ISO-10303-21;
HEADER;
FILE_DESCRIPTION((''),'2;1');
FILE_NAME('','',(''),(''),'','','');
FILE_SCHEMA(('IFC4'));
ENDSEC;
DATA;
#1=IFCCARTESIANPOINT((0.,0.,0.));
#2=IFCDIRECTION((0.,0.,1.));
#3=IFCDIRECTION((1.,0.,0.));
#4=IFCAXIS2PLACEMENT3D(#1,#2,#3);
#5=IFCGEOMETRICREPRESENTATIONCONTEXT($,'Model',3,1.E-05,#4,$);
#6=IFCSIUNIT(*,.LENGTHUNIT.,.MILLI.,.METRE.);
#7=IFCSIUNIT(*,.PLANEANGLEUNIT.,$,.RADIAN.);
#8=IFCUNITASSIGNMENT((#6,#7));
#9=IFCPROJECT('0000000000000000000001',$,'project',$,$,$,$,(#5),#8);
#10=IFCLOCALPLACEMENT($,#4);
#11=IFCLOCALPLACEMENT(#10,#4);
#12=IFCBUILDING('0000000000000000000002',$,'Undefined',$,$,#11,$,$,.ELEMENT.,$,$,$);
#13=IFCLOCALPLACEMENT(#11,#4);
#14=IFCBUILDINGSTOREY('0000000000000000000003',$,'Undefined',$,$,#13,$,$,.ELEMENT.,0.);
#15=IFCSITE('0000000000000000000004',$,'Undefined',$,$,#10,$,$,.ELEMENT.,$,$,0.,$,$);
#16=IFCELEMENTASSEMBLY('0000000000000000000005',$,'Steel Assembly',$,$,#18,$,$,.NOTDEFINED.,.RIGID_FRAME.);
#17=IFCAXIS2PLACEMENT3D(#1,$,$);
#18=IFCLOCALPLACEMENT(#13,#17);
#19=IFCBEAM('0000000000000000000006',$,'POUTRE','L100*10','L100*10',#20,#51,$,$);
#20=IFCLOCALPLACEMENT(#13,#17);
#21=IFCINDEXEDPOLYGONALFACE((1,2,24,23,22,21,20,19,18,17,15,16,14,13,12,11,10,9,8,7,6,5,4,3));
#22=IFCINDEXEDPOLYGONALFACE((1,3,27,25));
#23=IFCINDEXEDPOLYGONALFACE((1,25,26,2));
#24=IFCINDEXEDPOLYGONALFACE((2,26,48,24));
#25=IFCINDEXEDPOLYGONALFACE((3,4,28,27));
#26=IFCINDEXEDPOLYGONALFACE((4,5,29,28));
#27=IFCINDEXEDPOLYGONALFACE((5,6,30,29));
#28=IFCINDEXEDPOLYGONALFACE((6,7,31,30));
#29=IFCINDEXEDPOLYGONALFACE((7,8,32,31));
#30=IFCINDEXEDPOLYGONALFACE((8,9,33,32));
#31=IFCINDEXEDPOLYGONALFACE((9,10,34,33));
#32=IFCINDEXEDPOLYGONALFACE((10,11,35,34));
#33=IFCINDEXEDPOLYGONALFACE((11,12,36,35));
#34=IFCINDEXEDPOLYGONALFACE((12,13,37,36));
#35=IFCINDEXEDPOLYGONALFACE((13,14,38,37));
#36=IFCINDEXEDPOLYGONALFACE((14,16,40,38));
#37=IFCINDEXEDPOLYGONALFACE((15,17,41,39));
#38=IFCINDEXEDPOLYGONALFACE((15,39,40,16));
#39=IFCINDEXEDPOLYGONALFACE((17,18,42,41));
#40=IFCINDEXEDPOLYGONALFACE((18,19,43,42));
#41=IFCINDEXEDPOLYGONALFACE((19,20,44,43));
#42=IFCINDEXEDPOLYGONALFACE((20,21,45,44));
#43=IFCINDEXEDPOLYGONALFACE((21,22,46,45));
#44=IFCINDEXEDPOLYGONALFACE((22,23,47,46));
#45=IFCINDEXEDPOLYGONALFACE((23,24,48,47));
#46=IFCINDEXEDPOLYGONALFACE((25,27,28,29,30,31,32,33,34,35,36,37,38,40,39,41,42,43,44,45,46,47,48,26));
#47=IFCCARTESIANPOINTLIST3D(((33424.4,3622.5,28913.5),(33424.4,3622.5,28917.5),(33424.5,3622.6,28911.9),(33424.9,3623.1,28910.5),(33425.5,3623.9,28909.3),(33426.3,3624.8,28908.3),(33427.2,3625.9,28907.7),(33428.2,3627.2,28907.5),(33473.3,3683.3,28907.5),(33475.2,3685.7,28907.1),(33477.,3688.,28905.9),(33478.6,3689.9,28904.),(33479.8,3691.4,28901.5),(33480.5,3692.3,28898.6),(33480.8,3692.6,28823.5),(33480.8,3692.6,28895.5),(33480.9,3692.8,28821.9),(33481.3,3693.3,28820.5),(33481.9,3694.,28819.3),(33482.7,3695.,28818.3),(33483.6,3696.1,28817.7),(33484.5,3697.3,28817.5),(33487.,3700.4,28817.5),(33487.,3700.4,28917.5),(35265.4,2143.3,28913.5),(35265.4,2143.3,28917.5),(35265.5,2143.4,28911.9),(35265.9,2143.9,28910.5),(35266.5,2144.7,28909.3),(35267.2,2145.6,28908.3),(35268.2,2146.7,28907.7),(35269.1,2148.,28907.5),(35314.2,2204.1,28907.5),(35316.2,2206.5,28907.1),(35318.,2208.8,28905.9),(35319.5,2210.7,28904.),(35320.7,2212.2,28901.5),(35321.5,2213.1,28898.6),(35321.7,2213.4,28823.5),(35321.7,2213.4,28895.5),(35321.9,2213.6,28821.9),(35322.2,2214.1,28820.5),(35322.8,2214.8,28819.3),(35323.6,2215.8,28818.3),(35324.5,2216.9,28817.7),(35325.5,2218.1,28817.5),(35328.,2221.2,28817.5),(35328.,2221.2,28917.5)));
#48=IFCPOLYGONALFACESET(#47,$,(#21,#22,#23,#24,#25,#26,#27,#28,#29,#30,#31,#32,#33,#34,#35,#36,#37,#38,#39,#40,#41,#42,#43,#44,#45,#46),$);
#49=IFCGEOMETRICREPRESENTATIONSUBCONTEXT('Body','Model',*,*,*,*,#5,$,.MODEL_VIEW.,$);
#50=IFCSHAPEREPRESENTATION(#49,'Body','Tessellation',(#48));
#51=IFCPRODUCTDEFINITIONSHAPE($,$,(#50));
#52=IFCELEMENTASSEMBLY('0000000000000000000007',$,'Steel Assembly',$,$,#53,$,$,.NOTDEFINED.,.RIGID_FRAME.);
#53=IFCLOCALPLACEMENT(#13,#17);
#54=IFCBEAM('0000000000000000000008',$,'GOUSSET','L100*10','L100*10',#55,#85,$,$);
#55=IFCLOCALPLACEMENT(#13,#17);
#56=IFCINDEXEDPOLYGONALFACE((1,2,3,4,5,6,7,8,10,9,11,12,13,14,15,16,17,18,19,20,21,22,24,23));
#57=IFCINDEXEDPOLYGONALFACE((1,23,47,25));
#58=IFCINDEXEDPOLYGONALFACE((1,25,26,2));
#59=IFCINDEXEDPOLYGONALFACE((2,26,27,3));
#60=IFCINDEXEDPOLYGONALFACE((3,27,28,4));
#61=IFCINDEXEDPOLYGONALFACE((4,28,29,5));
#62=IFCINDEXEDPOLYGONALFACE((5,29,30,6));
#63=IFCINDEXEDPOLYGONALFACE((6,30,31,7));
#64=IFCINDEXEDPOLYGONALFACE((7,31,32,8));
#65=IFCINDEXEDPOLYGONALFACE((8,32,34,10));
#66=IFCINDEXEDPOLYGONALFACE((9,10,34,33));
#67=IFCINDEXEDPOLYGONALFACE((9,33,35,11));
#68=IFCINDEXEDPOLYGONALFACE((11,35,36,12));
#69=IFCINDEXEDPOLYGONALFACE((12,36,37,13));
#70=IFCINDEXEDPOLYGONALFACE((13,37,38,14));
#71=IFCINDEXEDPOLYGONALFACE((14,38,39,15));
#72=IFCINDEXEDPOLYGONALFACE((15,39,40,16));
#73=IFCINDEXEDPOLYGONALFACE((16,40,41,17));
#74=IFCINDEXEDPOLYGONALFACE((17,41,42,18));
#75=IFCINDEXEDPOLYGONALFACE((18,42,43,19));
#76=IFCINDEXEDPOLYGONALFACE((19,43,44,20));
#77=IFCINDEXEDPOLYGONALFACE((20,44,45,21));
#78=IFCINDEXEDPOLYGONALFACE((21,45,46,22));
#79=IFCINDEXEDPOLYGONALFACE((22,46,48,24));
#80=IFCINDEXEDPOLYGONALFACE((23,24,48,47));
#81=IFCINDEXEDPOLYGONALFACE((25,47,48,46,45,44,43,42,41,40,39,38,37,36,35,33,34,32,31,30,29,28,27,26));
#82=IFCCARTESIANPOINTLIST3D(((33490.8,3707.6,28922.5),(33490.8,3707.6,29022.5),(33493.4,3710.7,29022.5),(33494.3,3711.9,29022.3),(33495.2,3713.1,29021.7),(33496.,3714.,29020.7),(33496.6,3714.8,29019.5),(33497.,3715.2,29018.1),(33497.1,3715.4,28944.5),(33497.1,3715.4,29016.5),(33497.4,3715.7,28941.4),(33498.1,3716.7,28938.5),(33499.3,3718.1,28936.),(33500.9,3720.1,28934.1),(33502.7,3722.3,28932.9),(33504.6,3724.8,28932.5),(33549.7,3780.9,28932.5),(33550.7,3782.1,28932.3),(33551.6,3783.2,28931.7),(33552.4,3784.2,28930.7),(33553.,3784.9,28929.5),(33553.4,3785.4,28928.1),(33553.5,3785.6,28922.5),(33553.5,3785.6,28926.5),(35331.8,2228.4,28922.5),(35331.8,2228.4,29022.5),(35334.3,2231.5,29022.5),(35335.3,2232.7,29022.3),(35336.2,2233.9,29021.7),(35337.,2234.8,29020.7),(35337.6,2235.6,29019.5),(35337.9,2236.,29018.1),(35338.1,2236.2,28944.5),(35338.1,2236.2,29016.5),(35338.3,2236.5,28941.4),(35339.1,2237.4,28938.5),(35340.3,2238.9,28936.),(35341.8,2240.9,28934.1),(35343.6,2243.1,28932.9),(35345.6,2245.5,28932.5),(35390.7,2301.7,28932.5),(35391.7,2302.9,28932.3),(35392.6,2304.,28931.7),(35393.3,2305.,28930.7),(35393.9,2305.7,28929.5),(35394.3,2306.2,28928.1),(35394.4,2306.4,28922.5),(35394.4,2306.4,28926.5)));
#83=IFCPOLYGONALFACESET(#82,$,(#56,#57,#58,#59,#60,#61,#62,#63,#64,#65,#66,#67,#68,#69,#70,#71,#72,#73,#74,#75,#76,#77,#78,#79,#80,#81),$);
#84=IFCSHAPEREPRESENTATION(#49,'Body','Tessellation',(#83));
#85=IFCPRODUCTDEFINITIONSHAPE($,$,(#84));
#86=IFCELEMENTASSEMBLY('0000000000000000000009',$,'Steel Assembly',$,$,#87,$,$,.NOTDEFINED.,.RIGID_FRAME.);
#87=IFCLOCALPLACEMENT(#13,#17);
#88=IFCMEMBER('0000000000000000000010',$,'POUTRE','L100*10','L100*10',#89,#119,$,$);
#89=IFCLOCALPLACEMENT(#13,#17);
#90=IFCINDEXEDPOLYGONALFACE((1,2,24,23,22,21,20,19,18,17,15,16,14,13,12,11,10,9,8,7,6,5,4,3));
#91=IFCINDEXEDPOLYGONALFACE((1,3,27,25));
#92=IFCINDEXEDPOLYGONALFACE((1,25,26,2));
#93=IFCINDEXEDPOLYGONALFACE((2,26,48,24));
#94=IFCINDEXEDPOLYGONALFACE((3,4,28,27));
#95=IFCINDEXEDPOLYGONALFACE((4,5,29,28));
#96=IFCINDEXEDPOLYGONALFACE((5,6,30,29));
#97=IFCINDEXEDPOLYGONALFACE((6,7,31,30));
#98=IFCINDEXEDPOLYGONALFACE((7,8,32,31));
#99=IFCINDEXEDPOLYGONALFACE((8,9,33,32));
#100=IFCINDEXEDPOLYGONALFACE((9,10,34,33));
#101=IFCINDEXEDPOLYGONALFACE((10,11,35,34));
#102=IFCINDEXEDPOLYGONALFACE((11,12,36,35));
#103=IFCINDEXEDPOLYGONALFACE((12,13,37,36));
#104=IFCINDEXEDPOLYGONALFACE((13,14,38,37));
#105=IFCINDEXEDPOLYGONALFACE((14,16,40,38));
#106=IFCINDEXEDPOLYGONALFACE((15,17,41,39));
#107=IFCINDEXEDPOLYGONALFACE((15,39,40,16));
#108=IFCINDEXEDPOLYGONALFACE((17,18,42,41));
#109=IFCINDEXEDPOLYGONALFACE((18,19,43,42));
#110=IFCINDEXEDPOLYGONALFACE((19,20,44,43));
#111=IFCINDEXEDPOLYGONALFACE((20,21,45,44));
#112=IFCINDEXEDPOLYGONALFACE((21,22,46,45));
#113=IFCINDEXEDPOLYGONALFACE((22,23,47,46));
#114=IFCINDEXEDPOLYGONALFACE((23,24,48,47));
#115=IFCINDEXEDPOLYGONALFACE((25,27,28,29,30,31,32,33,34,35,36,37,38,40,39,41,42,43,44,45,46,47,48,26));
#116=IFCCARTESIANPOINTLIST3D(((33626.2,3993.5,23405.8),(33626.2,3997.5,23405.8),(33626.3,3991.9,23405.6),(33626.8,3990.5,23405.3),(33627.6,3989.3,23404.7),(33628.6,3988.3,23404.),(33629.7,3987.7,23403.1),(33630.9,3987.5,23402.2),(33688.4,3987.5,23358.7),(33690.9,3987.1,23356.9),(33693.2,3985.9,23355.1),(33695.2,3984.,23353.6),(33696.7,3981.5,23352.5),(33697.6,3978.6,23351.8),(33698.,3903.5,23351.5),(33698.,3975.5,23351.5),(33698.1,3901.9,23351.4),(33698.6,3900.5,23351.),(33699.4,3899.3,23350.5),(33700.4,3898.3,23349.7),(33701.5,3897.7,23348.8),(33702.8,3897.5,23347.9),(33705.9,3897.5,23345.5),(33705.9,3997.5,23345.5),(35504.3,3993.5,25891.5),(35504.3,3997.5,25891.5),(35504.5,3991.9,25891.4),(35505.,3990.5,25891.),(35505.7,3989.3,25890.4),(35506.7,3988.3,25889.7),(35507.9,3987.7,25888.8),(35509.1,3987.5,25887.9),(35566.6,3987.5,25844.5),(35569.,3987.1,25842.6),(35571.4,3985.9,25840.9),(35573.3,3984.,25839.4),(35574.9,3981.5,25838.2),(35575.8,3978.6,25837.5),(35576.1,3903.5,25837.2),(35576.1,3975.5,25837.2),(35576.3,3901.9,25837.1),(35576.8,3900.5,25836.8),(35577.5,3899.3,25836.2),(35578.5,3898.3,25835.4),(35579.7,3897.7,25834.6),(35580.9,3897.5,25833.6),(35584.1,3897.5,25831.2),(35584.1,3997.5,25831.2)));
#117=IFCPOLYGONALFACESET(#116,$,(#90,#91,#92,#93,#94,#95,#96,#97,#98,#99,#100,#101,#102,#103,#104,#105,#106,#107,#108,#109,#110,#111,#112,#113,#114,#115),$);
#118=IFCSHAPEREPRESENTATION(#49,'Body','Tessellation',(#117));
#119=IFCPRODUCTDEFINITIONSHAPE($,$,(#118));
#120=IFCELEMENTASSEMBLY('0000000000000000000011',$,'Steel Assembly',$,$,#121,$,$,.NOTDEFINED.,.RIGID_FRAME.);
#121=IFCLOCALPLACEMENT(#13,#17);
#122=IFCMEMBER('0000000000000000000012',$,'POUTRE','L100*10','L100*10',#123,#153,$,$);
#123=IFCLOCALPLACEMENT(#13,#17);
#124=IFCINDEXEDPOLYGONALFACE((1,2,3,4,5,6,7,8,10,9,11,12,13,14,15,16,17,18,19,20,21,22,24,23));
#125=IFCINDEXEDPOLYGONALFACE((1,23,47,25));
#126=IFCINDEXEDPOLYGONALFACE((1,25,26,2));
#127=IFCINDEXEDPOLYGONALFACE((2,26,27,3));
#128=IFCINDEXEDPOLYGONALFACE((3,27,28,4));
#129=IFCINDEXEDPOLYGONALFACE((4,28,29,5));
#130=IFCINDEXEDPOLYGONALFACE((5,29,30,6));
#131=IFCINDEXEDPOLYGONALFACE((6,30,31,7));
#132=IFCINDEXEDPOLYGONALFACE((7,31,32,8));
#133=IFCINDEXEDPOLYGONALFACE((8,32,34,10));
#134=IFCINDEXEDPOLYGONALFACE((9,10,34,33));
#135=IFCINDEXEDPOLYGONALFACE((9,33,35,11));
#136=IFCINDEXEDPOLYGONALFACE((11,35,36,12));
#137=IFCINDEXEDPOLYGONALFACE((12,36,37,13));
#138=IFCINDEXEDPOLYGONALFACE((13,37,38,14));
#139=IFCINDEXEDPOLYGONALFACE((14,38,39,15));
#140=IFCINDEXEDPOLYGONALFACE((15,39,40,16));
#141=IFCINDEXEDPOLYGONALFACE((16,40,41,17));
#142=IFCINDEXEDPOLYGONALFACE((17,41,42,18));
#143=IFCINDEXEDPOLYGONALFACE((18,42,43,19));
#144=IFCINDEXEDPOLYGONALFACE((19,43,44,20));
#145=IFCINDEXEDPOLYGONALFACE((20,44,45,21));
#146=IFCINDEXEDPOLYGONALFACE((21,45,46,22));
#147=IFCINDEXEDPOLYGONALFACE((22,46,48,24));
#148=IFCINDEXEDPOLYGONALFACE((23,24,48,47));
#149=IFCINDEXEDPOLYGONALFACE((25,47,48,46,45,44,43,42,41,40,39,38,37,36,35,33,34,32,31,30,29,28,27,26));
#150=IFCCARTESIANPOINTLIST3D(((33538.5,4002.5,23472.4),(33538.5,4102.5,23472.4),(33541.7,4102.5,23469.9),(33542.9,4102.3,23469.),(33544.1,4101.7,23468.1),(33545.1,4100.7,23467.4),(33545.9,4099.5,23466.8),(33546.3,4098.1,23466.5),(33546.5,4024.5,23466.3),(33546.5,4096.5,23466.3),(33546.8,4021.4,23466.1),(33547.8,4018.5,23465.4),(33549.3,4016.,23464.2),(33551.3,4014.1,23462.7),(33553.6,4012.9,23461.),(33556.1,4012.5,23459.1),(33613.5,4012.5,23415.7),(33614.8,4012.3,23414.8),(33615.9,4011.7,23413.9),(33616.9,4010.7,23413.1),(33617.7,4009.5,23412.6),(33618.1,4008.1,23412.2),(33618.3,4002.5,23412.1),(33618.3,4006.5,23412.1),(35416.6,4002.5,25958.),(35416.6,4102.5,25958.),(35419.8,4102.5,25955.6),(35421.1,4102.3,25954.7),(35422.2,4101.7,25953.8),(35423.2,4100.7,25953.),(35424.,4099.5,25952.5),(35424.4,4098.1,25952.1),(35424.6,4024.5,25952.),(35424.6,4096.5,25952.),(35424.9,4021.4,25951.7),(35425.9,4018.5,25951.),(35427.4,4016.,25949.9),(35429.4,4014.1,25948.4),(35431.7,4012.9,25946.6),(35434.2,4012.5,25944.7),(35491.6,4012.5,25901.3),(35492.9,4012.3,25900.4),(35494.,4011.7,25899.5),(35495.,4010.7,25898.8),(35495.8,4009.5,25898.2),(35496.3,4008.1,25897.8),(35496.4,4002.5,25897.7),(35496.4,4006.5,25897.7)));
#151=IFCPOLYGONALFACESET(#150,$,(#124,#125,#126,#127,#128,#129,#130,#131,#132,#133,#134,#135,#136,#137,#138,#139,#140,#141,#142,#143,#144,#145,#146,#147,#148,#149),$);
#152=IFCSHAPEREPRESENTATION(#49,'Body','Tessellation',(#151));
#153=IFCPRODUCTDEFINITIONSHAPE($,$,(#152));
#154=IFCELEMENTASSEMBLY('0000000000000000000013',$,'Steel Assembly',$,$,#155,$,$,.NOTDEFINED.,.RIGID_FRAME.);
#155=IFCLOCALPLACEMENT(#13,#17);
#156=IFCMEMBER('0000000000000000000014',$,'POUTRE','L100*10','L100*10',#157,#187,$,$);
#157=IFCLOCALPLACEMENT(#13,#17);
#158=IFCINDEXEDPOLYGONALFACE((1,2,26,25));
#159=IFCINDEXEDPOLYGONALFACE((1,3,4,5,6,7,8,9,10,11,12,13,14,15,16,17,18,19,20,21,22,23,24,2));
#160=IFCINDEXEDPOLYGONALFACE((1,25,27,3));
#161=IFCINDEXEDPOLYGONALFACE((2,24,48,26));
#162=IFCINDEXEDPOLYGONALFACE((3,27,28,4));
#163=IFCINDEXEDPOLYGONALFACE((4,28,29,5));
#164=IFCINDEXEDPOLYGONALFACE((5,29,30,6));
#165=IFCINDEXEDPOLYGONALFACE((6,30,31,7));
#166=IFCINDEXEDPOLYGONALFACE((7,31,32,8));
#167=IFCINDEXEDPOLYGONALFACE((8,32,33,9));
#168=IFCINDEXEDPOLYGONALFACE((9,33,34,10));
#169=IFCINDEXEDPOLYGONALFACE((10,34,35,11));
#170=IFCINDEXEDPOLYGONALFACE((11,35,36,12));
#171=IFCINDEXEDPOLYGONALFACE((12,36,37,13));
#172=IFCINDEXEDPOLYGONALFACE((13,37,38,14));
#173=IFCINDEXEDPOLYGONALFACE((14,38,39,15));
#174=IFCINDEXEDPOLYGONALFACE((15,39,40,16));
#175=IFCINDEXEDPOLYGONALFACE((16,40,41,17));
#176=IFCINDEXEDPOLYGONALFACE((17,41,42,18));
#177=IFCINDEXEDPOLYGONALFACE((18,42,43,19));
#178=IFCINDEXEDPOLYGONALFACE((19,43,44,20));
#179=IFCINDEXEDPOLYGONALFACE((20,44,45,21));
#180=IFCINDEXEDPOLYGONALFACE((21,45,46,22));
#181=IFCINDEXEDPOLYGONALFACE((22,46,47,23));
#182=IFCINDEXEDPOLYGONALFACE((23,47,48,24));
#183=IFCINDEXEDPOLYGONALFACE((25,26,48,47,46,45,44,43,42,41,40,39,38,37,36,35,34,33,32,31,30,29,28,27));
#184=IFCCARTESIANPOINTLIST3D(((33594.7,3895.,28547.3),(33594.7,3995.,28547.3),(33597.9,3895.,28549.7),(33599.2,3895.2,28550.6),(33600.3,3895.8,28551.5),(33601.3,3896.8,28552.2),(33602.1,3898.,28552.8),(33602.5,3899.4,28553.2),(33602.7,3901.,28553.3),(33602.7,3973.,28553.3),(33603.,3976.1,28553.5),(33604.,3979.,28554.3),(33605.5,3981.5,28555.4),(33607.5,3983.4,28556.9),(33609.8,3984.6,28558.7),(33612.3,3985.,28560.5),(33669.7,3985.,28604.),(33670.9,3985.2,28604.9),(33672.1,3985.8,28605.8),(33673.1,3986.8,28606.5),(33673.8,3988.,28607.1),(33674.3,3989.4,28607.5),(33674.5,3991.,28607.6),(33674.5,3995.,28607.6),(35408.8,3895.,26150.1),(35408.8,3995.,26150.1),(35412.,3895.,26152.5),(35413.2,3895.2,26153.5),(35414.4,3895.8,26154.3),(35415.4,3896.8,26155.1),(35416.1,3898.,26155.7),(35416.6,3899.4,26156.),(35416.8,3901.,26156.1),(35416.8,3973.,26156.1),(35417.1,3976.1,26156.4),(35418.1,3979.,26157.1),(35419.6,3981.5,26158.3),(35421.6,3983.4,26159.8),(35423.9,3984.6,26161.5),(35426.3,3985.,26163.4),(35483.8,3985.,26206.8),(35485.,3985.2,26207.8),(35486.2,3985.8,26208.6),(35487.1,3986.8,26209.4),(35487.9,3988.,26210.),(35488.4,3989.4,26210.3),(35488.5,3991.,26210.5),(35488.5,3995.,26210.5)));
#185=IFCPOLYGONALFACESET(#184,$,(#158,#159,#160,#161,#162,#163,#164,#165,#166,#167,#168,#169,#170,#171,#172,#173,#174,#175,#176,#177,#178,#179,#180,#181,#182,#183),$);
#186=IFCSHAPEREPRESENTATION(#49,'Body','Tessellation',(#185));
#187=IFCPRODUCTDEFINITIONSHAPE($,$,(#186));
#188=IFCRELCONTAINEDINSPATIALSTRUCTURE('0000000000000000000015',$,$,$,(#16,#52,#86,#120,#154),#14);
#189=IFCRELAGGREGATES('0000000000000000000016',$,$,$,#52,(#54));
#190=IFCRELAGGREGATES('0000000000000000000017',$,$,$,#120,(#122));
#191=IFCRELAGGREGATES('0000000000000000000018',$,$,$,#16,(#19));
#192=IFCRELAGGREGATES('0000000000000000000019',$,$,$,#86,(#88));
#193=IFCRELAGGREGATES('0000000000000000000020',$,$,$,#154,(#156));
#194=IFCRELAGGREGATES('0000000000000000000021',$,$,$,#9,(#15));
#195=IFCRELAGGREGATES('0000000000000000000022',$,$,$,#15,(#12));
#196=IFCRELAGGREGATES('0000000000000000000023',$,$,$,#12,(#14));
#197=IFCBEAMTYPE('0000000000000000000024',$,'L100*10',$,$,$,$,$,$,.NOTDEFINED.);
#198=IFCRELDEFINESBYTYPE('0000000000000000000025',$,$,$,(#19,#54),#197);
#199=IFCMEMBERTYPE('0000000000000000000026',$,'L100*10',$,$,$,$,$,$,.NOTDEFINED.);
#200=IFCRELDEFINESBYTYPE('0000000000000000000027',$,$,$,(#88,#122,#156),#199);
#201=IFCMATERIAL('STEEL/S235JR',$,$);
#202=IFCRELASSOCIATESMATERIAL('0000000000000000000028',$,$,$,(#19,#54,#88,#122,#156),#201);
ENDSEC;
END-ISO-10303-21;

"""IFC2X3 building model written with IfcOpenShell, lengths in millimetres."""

from ifc_helpers import new_model, si_unit, frame, origin_with_axes, origin_2d_with_axis, place, context, subcontext, project, spatial, l_section, extrude, clip, halfspace, material, type_object, element, aggregate, save


model = new_model("IFC2X3")

# Units and contexts
model_context = context("Model", 3, precision=1e-05, world=origin_with_axes())
body_context = subcontext(model_context, "Body", "Model", "MODEL_VIEW")
ifc_project = project(units=[si_unit("LENGTHUNIT", "METRE", prefix="MILLI"), si_unit("PLANEANGLEUNIT", "RADIAN")], contexts=[model_context])

# Site, building, storey
site_placement = place(None, origin_with_axes())
site = spatial("IfcSite", under=ifc_project, at=site_placement, Name="Undefined", CompositionType="ELEMENT", RefElevation=0.0)
building_placement = place(site_placement, origin_with_axes())
building = spatial("IfcBuilding", under=site, at=building_placement, Name="Undefined", CompositionType="ELEMENT")
storey_placement = place(building_placement, origin_with_axes())
storey = spatial("IfcBuildingStorey", under=building, at=storey_placement, Name="Undefined", CompositionType="ELEMENT", Elevation=0.0)

# Element assemblies, beams
assembly_1_placement = place(storey_placement, origin_with_axes())
assembly_1 = element("IfcElementAssembly", 1, at=assembly_1_placement, inside=storey, Name="Steel Assembly", AssemblyPlace="NOTDEFINED", PredefinedType="RIGID_FRAME")
ifc_material_1 = material(Name="STEEL/S235JR")
beam_type = type_object("IfcBeamType", Name="L100*10", PredefinedType="NOTDEFINED")
beam_1_placement = place(assembly_1_placement, frame((35296.7, 2182.3, 28867.5), z_axis=(0.0, 0.0, -1.0), x_axis=(-0.779537, 0.626356, 0.0)))
beam_1 = element("IfcBeam", 2, at=beam_1_placement, type_object=beam_type, material=ifc_material_1, Name="POUTRE", Description="L100*10", ObjectType="L100*10", context=body_context, shape_type="SweptSolid", body=[
    extrude(l_section(Depth=100.0, Width=100.0, Thickness=10.0, FilletRadius=12.0, EdgeRadius=6.0, at=origin_2d_with_axis()), frame((2361.6, 0.0, 0.0), z_axis=(-1.0, 0.0, 0.0), x_axis=(0.0, -1.0, 0.0)), (0.0, 0.0, 1.0), 2361.6),
])
assembly_2_placement = place(storey_placement, origin_with_axes())
assembly_2 = element("IfcElementAssembly", 3, at=assembly_2_placement, inside=storey, Name="Steel Assembly", AssemblyPlace="NOTDEFINED", PredefinedType="RIGID_FRAME")
beam_2_placement = place(assembly_2_placement, frame((35363.1, 2267.4, 28972.5), z_axis=(0.0, 0.0, 1.0), x_axis=(-0.779537, 0.626356, 0.0)))
beam_2 = element("IfcBeam", 4, at=beam_2_placement, type_object=beam_type, material=ifc_material_1, Name="GOUSSET", Description="L100*10", ObjectType="L100*10", context=body_context, shape_type="SweptSolid", body=[
    extrude(l_section(Depth=100.0, Width=100.0, Thickness=10.0, FilletRadius=12.0, EdgeRadius=6.0, at=origin_2d_with_axis()), frame((2361.6, 0.0, 0.0), z_axis=(-1.0, 0.0, 0.0), x_axis=(0.0, -1.0, 0.0)), (0.0, 0.0, 1.0), 2361.6),
])
aggregate(assembly_2, [beam_2])

# Element assemblies, members
assembly_3_placement = place(storey_placement, origin_with_axes())
assembly_3 = element("IfcElementAssembly", 5, at=assembly_3_placement, inside=storey, Name="Steel Assembly", AssemblyPlace="NOTDEFINED", PredefinedType="RIGID_FRAME")
member_type = type_object("IfcMemberType", Name="L100*10", PredefinedType="NOTDEFINED")
member_1_placement = place(assembly_3_placement, frame((33666.0, 3947.5, 23375.6), z_axis=(-0.797857, 0.0, 0.602847), x_axis=(0.602847, 0.0, 0.797857)))
member_1 = element("IfcMember", 6, at=member_1_placement, type_object=member_type, material=ifc_material_1, Name="POUTRE", Description="L100*10", ObjectType="L100*10", context=body_context, shape_type="SweptSolid", body=[
    extrude(l_section(Depth=100.0, Width=100.0, Thickness=10.0, FilletRadius=12.0, EdgeRadius=6.0, at=origin_2d_with_axis()), frame((3115.5, 0.0, 0.0), z_axis=(-1.0, 0.0, 0.0), x_axis=(0.0, -1.0, 0.0)), (0.0, 0.0, 1.0), 3115.5),
])
assembly_4_placement = place(storey_placement, origin_with_axes())
assembly_4 = element("IfcElementAssembly", 7, at=assembly_4_placement, inside=storey, Name="Steel Assembly", AssemblyPlace="NOTDEFINED", PredefinedType="RIGID_FRAME")
member_2_placement = place(assembly_4_placement, frame((33578.4, 4052.5, 23442.2), z_axis=(0.797856, 0.0, -0.602848), x_axis=(0.602847, 0.0, 0.797857)))
member_2 = element("IfcMember", 8, at=member_2_placement, type_object=member_type, material=ifc_material_1, Name="POUTRE", Description="L100*10", ObjectType="L100*10", context=body_context, shape_type="SweptSolid", body=[
    extrude(l_section(Depth=100.0, Width=100.0, Thickness=10.0, FilletRadius=12.0, EdgeRadius=6.0, at=origin_2d_with_axis()), frame((3115.4, 0.0, 0.0), z_axis=(-1.0, 0.0, 0.0), x_axis=(0.0, -1.0, 0.0)), (0.0, 0.0, 1.0), 3115.4),
])
aggregate(assembly_4, [member_2])
assembly_5_placement = place(storey_placement, origin_with_axes())
assembly_5 = element("IfcElementAssembly", 9, at=assembly_5_placement, inside=storey, Name="Steel Assembly", AssemblyPlace="NOTDEFINED", PredefinedType="RIGID_FRAME")
member_3_placement = place(assembly_5_placement, frame((33634.6, 3945.0, 28577.4), z_axis=(0.797403, 0.0, 0.603447), x_axis=(0.603447, 0.0, -0.797403)))
member_3 = element("IfcMember", 10, at=member_3_placement, type_object=member_type, material=ifc_material_1, Name="POUTRE", Description="L100*10", ObjectType="L100*10", context=body_context, shape_type="Clipping", body=[
    clip(extrude(l_section(Depth=100.0, Width=100.0, Thickness=10.0, FilletRadius=12.0, EdgeRadius=6.0, at=origin_2d_with_axis()), frame((6780.5, 0.0, 0.0), z_axis=(-1.0, 0.0, 0.0), x_axis=(0.0, -1.0, 0.0)), (0.0, 0.0, 1.0), 6780.5), halfspace(frame((3006.1, -50.0, 50.0), z_axis=(1.0, 0.0, 0.0), x_axis=(0.0, 1.0, 0.0)), False)),
])

aggregate(assembly_1, [beam_1])

aggregate(assembly_3, [member_1])
aggregate(assembly_5, [member_3])

save(model, "model.ifc")
